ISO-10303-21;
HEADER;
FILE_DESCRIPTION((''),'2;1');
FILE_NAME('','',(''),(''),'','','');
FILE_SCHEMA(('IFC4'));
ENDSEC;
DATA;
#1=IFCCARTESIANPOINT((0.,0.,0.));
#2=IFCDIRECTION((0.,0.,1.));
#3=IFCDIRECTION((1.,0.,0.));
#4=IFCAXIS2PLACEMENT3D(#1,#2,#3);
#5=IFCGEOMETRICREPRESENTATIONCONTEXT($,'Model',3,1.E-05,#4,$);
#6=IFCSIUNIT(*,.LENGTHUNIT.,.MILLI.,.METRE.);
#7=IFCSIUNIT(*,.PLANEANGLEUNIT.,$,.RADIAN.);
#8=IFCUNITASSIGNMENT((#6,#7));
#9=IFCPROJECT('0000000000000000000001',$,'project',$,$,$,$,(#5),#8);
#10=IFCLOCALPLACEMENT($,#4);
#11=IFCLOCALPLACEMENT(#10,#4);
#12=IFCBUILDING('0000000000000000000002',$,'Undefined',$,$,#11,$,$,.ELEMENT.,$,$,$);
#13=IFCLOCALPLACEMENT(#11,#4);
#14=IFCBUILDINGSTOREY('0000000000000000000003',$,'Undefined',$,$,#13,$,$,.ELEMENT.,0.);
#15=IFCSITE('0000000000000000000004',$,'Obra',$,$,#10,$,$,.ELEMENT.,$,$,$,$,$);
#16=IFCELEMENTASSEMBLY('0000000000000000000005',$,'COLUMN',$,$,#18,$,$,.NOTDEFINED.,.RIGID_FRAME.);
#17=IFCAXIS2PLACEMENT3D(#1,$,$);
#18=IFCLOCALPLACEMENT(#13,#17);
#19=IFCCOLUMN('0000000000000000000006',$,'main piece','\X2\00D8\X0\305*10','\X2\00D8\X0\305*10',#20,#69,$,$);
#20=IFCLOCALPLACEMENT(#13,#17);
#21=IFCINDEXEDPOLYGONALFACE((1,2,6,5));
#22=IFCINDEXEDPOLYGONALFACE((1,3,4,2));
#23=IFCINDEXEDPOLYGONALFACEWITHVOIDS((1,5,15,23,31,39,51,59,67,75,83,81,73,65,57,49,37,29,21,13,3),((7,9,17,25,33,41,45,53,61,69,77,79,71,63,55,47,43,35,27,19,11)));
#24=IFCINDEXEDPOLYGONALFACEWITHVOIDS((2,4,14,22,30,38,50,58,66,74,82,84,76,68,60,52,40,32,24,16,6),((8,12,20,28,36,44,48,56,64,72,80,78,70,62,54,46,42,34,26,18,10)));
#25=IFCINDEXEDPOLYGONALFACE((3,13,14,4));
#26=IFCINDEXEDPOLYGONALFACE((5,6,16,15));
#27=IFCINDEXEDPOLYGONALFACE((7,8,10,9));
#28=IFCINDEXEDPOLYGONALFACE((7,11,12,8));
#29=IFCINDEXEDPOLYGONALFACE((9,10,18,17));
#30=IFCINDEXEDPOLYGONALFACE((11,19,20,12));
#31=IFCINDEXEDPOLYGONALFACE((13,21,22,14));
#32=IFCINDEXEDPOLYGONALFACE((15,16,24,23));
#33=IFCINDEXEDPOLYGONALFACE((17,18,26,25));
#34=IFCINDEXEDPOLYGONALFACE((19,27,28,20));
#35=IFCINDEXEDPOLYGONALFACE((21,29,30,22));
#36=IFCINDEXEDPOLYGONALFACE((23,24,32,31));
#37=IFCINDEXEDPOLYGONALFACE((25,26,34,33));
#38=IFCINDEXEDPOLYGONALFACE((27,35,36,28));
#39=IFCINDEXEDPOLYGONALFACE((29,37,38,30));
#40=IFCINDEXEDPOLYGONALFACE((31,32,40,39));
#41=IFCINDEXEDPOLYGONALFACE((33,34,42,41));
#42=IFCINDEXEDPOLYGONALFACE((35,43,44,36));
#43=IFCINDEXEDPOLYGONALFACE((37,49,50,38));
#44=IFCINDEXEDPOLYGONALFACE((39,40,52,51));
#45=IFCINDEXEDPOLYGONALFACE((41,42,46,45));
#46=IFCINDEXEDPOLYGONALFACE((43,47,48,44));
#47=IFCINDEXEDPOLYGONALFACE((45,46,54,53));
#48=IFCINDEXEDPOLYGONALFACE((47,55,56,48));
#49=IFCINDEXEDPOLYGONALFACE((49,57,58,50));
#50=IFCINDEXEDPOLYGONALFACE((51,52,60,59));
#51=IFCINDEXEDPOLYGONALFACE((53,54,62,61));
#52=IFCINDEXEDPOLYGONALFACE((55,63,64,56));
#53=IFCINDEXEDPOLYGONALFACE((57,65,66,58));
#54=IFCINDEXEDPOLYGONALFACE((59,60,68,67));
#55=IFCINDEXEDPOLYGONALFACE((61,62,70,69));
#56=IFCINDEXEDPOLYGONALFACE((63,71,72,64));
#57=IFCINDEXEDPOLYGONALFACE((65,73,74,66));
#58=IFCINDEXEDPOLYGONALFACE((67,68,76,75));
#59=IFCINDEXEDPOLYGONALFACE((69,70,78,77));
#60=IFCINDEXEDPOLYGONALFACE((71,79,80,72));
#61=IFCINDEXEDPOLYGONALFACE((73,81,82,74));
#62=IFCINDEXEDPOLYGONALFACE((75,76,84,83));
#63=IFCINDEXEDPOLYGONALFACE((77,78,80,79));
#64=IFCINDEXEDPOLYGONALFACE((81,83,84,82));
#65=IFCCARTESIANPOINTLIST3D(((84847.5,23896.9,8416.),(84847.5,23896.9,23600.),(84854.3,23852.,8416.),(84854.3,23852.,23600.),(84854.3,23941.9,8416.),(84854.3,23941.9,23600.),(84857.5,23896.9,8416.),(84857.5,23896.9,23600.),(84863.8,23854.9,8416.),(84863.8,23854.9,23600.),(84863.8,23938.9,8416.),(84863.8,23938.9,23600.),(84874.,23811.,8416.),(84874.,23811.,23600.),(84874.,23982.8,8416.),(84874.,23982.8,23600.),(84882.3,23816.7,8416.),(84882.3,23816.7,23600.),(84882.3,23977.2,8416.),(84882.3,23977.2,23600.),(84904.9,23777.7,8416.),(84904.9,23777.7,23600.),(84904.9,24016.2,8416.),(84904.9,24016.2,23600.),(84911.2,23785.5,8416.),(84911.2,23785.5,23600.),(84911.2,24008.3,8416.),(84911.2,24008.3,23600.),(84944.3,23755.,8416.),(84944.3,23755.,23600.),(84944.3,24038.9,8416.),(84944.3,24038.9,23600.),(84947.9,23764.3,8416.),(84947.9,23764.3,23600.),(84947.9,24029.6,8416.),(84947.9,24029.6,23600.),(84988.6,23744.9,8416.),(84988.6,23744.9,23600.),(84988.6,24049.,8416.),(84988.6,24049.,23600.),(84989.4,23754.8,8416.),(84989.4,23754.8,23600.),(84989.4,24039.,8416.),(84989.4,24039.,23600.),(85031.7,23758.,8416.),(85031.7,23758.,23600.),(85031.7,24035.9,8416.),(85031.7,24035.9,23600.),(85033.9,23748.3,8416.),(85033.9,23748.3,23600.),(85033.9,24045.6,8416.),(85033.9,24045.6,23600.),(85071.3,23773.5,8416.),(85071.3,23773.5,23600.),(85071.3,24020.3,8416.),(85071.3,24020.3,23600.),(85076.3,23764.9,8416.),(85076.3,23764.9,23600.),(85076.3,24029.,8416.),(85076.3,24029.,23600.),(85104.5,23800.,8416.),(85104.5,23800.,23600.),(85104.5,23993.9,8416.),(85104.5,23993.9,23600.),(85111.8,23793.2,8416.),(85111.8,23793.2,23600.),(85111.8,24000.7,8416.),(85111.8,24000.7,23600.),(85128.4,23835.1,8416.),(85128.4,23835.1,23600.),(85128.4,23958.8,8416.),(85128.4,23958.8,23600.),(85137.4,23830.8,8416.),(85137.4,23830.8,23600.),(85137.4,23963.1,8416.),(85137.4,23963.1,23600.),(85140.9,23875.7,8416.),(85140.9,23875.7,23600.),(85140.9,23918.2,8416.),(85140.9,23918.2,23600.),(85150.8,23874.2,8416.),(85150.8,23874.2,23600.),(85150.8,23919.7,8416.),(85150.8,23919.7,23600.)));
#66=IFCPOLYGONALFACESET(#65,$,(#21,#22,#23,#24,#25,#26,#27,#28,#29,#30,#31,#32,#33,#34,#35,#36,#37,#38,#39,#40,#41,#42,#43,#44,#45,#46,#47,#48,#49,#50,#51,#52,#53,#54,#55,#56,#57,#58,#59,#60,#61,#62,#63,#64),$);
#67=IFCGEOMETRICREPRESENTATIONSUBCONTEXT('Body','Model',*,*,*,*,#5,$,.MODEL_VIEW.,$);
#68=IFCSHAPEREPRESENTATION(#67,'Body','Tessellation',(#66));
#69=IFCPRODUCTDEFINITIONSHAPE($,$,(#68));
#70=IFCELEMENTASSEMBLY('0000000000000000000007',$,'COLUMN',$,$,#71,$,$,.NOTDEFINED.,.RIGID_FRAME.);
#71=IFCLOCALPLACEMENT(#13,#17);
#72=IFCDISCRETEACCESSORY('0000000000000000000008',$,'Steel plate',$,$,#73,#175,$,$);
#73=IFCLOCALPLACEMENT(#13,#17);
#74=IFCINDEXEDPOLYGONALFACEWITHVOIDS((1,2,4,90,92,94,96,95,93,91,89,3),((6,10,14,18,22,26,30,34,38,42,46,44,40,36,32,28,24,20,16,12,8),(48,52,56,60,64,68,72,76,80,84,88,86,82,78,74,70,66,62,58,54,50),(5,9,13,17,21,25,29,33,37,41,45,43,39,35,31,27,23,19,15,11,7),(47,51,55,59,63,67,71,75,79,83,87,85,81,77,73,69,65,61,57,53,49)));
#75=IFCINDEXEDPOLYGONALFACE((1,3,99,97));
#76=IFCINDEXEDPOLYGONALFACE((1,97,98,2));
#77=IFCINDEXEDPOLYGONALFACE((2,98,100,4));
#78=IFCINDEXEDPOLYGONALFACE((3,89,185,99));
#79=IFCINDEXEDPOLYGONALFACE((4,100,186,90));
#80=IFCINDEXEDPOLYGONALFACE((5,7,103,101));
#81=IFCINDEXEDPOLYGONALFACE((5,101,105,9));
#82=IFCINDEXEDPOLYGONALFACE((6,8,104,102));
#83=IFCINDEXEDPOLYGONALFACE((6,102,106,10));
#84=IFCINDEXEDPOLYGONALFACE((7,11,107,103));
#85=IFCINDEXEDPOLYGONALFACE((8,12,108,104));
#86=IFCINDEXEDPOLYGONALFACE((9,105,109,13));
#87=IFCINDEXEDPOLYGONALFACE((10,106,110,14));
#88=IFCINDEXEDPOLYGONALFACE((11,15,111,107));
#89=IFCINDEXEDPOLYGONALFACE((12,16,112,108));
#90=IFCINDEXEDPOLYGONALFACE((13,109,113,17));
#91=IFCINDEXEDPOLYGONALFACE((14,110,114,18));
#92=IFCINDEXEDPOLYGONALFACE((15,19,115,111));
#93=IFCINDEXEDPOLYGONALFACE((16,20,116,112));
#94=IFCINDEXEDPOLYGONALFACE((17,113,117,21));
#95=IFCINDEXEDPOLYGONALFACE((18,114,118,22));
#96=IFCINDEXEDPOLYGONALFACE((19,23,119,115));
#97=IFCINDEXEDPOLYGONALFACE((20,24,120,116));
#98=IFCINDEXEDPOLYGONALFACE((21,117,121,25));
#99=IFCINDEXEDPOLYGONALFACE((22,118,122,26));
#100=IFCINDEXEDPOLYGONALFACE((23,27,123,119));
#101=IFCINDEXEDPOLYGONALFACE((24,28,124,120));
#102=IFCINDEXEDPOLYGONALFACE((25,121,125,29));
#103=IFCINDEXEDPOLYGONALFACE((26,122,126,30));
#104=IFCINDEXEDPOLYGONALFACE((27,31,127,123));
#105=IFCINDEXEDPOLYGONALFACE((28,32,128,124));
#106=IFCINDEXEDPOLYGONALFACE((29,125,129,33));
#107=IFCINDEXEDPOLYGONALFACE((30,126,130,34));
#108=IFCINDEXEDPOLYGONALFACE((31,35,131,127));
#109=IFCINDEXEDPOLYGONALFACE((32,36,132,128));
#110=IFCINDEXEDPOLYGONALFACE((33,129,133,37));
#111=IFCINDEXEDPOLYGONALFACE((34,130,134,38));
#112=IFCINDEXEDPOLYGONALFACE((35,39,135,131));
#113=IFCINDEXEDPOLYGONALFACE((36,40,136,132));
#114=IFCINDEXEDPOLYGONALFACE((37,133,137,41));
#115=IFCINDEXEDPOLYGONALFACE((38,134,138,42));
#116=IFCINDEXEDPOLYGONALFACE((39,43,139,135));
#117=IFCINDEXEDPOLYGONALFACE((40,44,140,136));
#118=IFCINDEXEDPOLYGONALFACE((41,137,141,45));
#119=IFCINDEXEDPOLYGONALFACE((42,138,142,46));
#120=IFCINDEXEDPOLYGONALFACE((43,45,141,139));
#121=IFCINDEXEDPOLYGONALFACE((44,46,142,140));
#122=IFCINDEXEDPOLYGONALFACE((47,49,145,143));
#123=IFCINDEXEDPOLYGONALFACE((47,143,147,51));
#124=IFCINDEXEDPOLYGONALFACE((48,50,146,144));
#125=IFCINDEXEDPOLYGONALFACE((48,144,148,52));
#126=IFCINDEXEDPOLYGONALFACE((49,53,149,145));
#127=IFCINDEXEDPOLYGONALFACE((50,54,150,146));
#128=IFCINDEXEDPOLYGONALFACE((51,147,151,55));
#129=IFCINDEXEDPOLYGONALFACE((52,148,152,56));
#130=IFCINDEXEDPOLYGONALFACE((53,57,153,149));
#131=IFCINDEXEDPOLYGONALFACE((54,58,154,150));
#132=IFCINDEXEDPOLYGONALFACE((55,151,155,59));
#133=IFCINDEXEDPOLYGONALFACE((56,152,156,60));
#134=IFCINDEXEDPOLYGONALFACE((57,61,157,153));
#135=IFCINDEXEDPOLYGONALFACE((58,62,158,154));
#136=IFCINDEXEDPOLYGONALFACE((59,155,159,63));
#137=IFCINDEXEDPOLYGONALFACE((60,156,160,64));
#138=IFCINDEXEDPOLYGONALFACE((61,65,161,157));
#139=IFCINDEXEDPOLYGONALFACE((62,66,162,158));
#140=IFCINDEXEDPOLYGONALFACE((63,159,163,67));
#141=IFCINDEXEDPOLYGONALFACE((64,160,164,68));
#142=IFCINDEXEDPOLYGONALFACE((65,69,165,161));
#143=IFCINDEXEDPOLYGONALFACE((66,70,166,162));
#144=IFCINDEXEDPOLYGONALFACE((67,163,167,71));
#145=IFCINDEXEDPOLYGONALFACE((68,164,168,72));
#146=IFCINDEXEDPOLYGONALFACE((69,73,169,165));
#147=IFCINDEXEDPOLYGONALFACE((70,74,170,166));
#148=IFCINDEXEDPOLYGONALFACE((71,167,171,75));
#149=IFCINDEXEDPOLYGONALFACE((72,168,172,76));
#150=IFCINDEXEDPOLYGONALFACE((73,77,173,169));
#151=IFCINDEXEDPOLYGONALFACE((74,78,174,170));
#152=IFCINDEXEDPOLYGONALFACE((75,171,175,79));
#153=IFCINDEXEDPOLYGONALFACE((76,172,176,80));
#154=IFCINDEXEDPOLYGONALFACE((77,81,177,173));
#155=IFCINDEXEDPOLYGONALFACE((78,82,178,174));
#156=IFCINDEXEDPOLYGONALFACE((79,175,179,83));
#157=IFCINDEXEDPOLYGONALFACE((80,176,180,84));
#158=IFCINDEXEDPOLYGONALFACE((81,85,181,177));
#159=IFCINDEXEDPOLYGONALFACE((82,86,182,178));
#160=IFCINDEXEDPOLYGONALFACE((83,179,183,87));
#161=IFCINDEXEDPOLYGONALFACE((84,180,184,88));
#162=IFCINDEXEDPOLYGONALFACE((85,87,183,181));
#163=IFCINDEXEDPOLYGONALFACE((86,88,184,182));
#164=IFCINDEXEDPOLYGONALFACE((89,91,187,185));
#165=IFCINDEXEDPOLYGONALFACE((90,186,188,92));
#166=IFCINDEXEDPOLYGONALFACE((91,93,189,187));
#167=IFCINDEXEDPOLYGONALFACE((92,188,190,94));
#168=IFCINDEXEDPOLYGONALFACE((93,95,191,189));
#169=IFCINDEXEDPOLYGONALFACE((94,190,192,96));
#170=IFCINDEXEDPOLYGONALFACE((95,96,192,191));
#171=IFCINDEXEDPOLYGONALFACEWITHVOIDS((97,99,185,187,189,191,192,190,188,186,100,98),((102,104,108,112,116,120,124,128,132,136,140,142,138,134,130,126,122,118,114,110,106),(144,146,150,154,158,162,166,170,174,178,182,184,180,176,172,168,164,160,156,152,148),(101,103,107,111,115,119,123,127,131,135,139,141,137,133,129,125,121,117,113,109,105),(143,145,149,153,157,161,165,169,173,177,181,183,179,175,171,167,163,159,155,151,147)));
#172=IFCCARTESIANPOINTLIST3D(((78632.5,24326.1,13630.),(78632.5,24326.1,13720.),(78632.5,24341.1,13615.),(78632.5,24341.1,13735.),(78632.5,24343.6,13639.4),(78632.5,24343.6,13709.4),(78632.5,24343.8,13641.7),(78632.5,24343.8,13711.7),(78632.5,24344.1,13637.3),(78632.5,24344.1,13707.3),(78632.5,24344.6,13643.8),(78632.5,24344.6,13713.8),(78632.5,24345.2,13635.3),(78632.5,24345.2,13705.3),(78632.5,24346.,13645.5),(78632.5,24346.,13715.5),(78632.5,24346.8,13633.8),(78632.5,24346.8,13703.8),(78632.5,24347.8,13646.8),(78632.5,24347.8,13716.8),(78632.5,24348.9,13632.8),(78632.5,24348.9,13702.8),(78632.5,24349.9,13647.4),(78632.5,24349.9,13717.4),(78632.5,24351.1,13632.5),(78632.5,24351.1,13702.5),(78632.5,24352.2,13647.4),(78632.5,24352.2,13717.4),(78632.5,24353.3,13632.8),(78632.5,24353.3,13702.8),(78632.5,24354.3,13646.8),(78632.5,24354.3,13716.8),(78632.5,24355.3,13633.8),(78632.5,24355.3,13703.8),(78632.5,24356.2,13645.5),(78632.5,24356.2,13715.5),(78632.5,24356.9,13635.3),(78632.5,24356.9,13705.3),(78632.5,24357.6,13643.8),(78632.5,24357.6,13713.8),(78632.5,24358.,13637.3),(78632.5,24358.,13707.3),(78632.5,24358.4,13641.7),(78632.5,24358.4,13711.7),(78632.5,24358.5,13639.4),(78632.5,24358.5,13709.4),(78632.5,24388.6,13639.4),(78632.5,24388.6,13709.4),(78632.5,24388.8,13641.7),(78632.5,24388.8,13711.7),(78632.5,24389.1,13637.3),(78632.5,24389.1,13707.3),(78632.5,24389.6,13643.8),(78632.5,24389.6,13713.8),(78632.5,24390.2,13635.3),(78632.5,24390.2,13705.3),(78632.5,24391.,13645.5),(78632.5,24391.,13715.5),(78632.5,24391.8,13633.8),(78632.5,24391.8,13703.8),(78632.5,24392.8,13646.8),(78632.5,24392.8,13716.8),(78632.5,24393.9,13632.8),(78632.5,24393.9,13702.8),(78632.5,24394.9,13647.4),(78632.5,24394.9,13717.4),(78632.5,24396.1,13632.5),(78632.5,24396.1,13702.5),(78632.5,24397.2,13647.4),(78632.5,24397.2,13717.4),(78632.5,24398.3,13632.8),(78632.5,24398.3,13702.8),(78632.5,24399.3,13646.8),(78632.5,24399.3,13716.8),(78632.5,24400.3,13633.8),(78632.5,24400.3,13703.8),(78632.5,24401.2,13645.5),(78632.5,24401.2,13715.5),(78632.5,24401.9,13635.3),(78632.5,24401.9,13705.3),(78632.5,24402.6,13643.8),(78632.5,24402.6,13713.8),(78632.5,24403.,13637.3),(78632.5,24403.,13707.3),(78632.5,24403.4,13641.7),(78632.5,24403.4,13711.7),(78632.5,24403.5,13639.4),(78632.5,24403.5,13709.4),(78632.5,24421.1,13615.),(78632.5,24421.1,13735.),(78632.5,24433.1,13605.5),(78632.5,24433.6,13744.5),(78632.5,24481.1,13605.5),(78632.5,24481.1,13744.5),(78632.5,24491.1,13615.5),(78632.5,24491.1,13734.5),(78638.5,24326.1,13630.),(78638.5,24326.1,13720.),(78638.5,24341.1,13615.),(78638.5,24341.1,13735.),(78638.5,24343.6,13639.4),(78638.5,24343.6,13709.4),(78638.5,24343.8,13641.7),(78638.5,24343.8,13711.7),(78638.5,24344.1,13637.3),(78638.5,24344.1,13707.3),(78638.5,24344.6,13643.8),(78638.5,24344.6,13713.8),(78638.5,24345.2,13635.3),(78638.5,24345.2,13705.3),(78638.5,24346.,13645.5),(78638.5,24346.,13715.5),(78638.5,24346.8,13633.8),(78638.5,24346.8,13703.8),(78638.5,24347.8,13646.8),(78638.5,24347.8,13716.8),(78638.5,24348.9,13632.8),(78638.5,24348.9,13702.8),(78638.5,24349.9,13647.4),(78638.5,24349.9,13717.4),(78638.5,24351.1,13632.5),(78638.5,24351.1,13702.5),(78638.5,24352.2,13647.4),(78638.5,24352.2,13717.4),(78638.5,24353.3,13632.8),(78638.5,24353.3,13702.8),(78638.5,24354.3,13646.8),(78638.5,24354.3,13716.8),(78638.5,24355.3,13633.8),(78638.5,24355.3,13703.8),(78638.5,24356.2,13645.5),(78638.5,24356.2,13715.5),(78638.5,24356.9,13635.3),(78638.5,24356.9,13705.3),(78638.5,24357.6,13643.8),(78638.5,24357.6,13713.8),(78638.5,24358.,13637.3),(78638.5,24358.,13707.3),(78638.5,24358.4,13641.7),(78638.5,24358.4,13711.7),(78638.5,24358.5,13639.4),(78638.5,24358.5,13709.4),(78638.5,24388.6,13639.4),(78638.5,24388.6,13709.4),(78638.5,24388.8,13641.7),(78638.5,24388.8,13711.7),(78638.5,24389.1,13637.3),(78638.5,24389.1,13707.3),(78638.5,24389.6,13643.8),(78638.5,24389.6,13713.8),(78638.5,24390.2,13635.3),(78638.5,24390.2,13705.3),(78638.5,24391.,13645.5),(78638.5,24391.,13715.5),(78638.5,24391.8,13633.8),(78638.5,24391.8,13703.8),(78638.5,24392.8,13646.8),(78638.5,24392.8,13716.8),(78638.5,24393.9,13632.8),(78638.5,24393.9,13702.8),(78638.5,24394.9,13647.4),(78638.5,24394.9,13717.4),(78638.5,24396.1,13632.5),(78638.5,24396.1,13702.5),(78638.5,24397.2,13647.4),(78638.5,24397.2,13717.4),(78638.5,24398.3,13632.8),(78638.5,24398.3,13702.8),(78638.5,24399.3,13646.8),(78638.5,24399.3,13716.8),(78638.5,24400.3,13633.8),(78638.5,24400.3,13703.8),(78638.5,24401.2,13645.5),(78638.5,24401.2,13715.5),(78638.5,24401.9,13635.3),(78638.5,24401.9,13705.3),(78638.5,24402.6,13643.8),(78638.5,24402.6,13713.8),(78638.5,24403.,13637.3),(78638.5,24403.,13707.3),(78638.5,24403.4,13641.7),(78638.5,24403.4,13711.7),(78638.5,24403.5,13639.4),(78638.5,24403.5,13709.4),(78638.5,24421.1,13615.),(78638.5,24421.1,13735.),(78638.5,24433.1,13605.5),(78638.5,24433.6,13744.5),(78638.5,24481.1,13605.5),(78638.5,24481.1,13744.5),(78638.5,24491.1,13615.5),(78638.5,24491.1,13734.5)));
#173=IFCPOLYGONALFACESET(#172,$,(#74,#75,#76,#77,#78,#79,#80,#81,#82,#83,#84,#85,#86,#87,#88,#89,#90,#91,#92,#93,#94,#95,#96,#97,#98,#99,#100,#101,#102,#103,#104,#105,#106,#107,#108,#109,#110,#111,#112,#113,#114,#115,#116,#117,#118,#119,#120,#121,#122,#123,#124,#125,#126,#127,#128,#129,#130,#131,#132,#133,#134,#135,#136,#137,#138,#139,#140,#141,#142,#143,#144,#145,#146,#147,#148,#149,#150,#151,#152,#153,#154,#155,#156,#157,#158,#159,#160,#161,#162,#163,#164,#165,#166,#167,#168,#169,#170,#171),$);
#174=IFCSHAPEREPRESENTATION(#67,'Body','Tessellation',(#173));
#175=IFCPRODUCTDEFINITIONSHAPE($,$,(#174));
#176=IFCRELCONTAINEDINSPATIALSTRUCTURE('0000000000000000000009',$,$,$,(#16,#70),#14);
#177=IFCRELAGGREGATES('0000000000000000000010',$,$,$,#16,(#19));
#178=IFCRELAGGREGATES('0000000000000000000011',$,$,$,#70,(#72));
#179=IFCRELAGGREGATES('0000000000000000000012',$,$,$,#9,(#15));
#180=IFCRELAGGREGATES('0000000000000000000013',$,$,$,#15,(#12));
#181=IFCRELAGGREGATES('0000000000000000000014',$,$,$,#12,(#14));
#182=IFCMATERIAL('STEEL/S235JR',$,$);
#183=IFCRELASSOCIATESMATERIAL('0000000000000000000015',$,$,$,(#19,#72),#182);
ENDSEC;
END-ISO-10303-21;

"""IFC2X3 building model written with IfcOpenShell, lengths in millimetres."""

from ifc_helpers import new_model, si_unit, frame, origin_with_axes, origin_2d_with_axis, place, context, subcontext, project, spatial, polyline, circle, hollow_circle, outline, extrude, clip, halfspace, source, transform, mapped, material, element, aggregate, save


model = new_model("IFC2X3")

# Units and contexts
model_context = context("Model", 3, precision=1e-05, world=origin_with_axes())
body_context = subcontext(model_context, "Body", "Model", "MODEL_VIEW")
ifc_project = project(units=[si_unit("LENGTHUNIT", "METRE", prefix="MILLI"), si_unit("PLANEANGLEUNIT", "RADIAN")], contexts=[model_context])

# Site, building, storey
site_placement = place(None, origin_with_axes())
site = spatial("IfcSite", under=ifc_project, at=site_placement, Name="Obra", CompositionType="ELEMENT")
building_placement = place(site_placement, origin_with_axes())
building = spatial("IfcBuilding", under=site, at=building_placement, Name="Undefined", CompositionType="ELEMENT")
storey_placement = place(building_placement, origin_with_axes())
storey = spatial("IfcBuildingStorey", under=building, at=storey_placement, Name="Undefined", CompositionType="ELEMENT", Elevation=0.0)

# Element assembly, column
assembly_1_placement = place(storey_placement, origin_with_axes())
assembly_1 = element("IfcElementAssembly", 1, at=assembly_1_placement, inside=storey, Name="COLUMN", AssemblyPlace="NOTDEFINED", PredefinedType="RIGID_FRAME")
ifc_material_1 = material(Name="STEEL/S235JR")
column_placement = place(assembly_1_placement, frame((85000.0, 23896.9, 8400.0), z_axis=(0.0, 0.0, 1.0), x_axis=(0.0, 1.0, 0.0)))
column = element("IfcColumn", 2, at=column_placement, material=ifc_material_1, Name="main piece", Description="Ø305*10", ObjectType="Ø305*10", context=body_context, shape_type="Clipping", body=[
    clip(extrude(hollow_circle(Radius=152.5, WallThickness=10.0, at=origin_2d_with_axis()), frame((0.0, 0.0, 15200.0), z_axis=(0.0, 0.0, -1.0), x_axis=(0.0, 1.0, 0.0)), (0.0, 0.0, 1.0), 15184.0), halfspace(frame((-152.5, 0.0, 16.0), z_axis=(0.0, 0.0, 1.0), x_axis=(0.0, 1.0, 0.0)), True)),
])

# Element assembly, discrete accessory, opening
assembly_2_placement = place(storey_placement, origin_with_axes())
assembly_2 = element("IfcElementAssembly", 3, at=assembly_2_placement, inside=storey, Name="COLUMN", AssemblyPlace="NOTDEFINED", PredefinedType="RIGID_FRAME")
discrete_accessory_1_placement = place(assembly_2_placement, frame((78635.5, 24491.1, 13615.5), z_axis=(-1.0, 0.0, 0.0), x_axis=(0.0, -0.707107, -0.707107)))
discrete_accessory_1 = element("IfcDiscreteAccessory", 4, at=discrete_accessory_1_placement, material=ifc_material_1, Name="Steel plate", context=body_context, shape_type="SweptSolid", body=[
    extrude(outline(polyline([(0.0, 0.0), (14.1, 0.0), (48.1, 33.9), (49.9, 49.1), (106.4, 105.7), (106.4, 126.9), (42.8, 190.6), (21.6, 190.6), (-35.0, 134.0), (-50.6, 131.9), (-84.1, 98.3), (-84.1, 84.1), (0.0, 0.0)])), frame((0.0, 0.0, -3.0), z_axis=(0.0, 0.0, 1.0), x_axis=(1.0, 0.0, 0.0)), (0.0, 0.0, 1.0), 6.0),
])
shared_shape_1 = source(origin_with_axes(), body_context, "Body", "SweptSolid", [
    extrude(circle(Radius=7.5, at=origin_2d_with_axis()), frame((0.0, 2.4, 0.0), z_axis=(0.0, 1.0, 0.0), x_axis=(1.0, 0.0, 0.0)), (0.0, 0.0, 1.0), 6.2),
])
opening_1_placement = place(assembly_2_placement, frame((78630.0, 24373.6, 13710.0), z_axis=(0.0, -1.0, 0.0), x_axis=(0.0, 0.0, -1.0)))
element("IfcOpeningElement", 5, at=opening_1_placement, cuts=discrete_accessory_1, ObjectType="Opening", context=body_context, shape_type="MappedRepresentation", body=[
    mapped(shared_shape_1, transform((0.0, 0.0, -22.5))),
    mapped(shared_shape_1, transform((70.0, 0.0, -22.5))),
    mapped(shared_shape_1, transform((0.0, 0.0, 22.5))),
    mapped(shared_shape_1, transform((70.0, 0.0, 22.5))),
])

aggregate(assembly_1, [column])

aggregate(assembly_2, [discrete_accessory_1])

save(model, "model.ifc")
